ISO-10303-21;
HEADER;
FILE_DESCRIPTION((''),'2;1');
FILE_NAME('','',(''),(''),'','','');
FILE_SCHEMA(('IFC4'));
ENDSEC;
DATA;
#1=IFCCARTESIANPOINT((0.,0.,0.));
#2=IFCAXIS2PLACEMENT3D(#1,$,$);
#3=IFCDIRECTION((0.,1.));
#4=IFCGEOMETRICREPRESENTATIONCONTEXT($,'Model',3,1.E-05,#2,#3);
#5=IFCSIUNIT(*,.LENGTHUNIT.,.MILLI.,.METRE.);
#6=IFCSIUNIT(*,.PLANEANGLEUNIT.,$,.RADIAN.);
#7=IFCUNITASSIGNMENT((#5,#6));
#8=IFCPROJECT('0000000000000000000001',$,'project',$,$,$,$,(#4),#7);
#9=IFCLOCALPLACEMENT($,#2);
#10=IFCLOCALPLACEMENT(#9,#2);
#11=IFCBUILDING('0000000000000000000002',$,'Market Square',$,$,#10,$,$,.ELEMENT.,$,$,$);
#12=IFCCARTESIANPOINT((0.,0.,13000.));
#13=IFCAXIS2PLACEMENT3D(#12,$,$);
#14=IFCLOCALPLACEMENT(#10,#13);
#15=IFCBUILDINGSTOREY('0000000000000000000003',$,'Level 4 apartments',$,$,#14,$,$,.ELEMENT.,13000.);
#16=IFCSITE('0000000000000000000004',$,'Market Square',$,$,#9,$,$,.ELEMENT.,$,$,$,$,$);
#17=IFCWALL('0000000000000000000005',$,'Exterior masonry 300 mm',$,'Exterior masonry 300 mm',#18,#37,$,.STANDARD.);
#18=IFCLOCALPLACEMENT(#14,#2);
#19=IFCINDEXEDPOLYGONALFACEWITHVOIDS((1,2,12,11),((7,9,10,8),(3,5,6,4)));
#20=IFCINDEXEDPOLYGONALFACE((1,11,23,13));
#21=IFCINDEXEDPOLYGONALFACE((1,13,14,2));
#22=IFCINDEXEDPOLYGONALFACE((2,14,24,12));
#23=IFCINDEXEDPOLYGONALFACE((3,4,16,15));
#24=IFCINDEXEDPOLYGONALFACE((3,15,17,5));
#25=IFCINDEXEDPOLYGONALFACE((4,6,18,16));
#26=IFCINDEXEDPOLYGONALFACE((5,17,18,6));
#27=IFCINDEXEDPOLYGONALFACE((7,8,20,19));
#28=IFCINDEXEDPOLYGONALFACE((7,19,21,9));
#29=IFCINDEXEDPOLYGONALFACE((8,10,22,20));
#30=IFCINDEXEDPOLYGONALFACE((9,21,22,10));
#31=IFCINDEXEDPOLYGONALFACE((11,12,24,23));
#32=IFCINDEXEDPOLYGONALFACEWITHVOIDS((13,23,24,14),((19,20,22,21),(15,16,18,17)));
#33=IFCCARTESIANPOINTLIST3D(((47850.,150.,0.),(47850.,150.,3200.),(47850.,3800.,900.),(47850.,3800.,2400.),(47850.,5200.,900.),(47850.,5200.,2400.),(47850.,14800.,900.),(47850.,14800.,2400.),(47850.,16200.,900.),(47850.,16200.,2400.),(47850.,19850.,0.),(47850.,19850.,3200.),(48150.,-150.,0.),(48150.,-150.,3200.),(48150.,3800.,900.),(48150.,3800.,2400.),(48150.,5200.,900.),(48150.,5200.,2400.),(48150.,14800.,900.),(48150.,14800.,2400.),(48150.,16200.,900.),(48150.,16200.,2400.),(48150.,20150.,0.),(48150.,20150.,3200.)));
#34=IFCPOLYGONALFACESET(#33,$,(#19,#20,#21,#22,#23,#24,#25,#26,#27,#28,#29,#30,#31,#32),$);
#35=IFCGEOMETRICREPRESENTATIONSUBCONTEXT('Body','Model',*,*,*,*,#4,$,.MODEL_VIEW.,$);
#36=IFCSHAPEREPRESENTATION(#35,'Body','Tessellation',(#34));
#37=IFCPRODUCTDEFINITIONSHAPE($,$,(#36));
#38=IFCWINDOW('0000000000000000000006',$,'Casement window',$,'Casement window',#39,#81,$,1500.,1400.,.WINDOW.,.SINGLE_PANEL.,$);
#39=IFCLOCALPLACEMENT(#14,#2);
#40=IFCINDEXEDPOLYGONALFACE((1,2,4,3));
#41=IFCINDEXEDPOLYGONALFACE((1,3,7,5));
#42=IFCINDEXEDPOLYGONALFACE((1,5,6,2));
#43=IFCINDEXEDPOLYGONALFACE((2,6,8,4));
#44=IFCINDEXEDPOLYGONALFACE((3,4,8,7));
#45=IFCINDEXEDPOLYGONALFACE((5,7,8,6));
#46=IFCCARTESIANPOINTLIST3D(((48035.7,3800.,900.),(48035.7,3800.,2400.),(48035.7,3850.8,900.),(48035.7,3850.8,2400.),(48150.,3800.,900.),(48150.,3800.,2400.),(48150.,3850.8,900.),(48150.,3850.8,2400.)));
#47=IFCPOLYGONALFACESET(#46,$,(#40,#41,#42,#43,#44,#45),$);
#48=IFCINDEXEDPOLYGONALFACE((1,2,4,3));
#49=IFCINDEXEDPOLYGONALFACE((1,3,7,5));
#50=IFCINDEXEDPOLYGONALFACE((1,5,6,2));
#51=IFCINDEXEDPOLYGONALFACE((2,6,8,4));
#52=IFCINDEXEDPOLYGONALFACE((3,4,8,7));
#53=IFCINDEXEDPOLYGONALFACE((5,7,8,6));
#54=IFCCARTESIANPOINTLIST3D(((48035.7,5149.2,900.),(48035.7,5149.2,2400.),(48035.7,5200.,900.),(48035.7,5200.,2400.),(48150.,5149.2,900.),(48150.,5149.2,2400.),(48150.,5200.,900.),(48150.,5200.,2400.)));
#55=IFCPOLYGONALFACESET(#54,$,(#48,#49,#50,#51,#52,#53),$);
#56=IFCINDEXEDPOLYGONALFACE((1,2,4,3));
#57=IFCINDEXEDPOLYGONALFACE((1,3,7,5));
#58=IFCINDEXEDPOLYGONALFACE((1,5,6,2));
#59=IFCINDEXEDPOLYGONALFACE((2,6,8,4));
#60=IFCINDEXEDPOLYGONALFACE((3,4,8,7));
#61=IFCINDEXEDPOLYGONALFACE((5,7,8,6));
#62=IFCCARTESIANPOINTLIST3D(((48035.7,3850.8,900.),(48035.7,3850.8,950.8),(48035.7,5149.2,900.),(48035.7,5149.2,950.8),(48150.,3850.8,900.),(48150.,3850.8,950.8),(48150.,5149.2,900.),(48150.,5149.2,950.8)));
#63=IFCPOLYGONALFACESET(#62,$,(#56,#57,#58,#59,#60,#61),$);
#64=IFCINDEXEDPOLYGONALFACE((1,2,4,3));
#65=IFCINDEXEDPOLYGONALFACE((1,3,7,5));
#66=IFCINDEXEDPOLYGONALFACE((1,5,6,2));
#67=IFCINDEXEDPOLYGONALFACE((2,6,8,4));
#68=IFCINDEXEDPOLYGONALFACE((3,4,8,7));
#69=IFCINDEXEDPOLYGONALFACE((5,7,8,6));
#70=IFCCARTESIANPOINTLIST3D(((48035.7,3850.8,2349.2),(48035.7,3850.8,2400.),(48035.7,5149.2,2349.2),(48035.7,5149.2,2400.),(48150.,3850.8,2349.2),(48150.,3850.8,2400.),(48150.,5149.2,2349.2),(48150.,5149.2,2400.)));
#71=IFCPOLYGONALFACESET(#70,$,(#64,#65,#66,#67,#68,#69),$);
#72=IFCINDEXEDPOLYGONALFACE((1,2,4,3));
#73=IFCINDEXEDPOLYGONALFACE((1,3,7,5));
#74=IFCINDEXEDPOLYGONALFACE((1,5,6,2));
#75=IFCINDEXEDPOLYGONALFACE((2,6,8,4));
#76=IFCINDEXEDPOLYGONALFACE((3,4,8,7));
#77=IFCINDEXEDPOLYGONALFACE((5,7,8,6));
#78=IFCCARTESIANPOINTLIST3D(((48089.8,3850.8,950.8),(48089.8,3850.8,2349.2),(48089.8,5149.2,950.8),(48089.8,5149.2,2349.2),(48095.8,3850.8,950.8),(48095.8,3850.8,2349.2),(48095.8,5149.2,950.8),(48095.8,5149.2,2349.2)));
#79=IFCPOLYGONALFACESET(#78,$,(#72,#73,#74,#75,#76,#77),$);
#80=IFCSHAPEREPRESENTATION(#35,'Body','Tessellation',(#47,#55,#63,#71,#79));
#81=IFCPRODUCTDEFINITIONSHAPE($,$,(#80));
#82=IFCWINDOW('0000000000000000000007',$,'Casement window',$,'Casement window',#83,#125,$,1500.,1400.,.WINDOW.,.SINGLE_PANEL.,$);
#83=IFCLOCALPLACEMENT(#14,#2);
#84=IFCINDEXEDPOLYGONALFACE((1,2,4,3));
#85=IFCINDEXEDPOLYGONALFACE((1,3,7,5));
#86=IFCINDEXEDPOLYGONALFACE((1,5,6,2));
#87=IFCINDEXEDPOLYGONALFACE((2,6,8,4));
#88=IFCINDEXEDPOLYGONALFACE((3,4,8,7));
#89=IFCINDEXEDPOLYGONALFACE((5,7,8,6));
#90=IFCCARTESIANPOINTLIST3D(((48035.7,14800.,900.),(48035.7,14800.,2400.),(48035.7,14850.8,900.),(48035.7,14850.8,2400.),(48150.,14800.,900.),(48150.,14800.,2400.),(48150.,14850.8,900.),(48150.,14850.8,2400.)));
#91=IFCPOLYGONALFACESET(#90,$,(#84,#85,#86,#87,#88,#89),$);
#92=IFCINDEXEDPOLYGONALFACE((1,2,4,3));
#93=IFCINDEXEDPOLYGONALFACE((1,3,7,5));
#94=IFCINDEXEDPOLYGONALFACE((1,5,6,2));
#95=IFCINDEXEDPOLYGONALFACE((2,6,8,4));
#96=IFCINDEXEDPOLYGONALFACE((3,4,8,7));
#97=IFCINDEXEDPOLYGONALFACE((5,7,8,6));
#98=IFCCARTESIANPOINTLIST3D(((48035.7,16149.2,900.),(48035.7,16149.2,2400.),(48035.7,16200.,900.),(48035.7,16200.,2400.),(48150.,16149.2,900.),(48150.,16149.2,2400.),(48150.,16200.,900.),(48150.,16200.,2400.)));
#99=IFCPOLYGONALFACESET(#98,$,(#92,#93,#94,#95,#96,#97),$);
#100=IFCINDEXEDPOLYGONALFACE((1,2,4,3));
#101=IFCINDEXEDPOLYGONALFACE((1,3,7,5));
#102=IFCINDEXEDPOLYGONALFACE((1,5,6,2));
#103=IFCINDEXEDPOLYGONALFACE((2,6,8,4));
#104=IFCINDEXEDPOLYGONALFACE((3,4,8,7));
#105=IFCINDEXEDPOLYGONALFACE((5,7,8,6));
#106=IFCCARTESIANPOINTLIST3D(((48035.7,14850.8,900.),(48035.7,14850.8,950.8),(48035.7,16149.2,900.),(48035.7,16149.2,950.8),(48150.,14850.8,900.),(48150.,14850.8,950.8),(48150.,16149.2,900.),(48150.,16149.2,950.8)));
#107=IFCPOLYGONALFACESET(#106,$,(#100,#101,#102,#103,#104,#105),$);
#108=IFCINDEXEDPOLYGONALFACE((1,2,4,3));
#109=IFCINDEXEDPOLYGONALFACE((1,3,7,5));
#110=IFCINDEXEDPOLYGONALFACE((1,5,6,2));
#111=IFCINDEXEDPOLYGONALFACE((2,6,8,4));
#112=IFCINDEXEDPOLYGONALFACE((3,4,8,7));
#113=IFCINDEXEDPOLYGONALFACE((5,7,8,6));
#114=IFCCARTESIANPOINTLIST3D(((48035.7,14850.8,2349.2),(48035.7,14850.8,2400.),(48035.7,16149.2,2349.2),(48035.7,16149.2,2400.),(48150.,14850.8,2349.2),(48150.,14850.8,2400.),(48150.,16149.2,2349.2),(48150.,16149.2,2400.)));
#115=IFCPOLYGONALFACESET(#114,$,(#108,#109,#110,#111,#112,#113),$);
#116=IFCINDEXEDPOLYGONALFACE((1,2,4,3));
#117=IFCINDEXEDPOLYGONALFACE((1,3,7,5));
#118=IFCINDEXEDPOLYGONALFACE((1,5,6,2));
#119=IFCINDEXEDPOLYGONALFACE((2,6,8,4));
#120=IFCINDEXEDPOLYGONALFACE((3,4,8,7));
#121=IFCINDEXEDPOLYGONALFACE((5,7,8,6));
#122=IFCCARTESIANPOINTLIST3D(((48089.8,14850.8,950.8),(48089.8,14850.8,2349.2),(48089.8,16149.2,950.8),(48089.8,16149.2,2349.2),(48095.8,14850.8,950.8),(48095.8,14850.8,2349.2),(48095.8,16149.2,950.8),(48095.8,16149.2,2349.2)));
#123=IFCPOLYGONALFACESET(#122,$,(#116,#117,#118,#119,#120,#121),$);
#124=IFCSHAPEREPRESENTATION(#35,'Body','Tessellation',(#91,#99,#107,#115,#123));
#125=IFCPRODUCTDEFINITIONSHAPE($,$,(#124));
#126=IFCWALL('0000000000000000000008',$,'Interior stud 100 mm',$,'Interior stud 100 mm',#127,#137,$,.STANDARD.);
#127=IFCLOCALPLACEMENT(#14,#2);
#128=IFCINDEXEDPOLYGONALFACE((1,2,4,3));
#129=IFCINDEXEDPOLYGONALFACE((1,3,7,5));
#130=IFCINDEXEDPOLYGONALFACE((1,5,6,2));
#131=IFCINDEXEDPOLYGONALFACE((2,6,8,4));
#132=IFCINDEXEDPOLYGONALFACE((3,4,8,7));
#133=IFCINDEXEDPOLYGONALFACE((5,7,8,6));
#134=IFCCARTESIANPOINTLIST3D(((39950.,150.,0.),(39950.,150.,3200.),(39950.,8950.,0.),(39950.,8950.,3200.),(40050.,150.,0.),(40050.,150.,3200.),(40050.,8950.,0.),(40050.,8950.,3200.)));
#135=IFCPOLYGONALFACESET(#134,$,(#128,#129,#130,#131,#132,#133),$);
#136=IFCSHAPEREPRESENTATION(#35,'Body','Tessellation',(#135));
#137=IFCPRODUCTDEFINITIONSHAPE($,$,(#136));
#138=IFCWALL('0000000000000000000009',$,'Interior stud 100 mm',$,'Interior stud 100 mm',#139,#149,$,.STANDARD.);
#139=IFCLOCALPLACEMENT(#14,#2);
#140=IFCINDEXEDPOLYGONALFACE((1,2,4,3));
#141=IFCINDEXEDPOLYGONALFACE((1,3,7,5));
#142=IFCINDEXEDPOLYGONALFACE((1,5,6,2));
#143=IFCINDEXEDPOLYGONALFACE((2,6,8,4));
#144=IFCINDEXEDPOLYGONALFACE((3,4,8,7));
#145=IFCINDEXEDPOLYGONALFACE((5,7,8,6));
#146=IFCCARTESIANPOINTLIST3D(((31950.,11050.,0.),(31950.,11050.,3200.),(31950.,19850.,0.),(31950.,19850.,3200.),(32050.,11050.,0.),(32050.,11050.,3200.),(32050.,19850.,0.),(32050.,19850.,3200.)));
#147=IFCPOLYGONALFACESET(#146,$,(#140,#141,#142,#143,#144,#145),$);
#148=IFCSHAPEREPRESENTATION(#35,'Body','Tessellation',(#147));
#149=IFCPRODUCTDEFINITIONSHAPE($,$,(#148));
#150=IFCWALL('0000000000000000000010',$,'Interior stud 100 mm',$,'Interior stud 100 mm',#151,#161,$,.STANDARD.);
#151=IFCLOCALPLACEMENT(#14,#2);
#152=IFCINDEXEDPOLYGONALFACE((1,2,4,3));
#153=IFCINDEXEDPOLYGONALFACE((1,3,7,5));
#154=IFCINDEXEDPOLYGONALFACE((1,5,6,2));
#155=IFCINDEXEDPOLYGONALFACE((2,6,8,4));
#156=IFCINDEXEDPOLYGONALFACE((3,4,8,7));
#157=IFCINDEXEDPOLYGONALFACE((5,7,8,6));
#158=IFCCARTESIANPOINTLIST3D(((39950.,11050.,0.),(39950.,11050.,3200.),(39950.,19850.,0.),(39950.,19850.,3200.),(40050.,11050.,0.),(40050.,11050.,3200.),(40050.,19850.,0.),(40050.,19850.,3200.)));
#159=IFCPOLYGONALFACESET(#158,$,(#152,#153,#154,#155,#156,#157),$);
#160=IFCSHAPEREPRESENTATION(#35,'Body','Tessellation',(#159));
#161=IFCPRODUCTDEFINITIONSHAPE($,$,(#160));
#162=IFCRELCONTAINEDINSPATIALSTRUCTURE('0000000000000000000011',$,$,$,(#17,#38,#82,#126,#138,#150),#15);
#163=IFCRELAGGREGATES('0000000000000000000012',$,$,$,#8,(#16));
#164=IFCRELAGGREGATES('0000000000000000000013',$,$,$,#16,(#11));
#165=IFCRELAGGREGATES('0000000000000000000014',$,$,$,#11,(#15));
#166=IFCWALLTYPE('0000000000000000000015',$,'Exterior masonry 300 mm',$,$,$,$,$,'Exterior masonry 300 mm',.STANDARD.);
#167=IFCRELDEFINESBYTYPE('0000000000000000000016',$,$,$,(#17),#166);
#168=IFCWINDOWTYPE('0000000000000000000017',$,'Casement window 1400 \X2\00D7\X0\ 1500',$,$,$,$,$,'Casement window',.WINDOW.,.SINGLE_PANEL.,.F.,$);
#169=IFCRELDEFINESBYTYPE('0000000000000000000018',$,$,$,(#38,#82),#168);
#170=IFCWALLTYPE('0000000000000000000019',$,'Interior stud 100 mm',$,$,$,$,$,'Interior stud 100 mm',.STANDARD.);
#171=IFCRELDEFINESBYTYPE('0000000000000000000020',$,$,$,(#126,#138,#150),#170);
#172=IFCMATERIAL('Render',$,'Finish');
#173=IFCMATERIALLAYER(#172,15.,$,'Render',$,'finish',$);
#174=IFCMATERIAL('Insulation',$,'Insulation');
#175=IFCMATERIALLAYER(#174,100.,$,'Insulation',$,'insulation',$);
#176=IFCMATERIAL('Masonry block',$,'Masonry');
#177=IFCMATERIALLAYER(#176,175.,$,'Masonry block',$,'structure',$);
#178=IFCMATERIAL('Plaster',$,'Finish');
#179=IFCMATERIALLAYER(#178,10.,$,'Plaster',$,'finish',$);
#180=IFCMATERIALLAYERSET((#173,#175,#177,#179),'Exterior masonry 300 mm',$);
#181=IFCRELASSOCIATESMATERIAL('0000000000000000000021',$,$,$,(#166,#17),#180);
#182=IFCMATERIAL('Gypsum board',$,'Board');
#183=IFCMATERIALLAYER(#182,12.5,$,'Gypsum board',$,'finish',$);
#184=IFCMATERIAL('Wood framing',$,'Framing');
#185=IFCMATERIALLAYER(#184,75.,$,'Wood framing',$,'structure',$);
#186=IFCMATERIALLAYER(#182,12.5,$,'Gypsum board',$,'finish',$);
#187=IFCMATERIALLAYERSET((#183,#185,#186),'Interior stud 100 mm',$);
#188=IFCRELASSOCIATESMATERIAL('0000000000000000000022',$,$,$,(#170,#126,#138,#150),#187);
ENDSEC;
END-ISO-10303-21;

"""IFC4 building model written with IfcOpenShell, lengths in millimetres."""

from ifc_helpers import new_model, si_unit, direction, frame, origin, origin_with_axes, place, context, subcontext, project, spatial, polyline, outline, extrude, material, layer, layer_set, layer_usage, type_object, element, fill, save


model = new_model("IFC4")

# Units and contexts
model_context = context("Model", 3, precision=1e-05, world=origin(), true_north=direction((0.0, 1.0)))
body_context = subcontext(model_context, "Body", "Model", "MODEL_VIEW")
ifc_project = project(units=[si_unit("LENGTHUNIT", "METRE", prefix="MILLI"), si_unit("PLANEANGLEUNIT", "RADIAN")], contexts=[model_context])

# Site, building, storey
site_placement = place(None, origin())
site = spatial("IfcSite", under=ifc_project, at=site_placement, Name="Market Square", CompositionType="ELEMENT")
building_placement = place(site_placement, origin())
building = spatial("IfcBuilding", under=site, at=building_placement, Name="Market Square", CompositionType="ELEMENT")
storey_placement = place(building_placement, frame((0.0, 0.0, 13000.0)))
storey = spatial("IfcBuildingStorey", under=building, at=storey_placement, Name="Level 4 apartments", CompositionType="ELEMENT", Elevation=13000.0)

# Wall, openings, windows
ifc_material_1 = material(Name="Render", Category="Finish")
ifc_layer_1 = layer(ifc_material_1, 15.0, Name="Render", Category="finish")
ifc_material_2 = material(Name="Insulation", Category="Insulation")
ifc_layer_2 = layer(ifc_material_2, 100.0, Name="Insulation", Category="insulation")
ifc_material_3 = material(Name="Masonry block", Category="Masonry")
ifc_layer_3 = layer(ifc_material_3, 175.0, Name="Masonry block", Category="structure")
ifc_material_4 = material(Name="Plaster", Category="Finish")
ifc_layer_4 = layer(ifc_material_4, 10.0, Name="Plaster", Category="finish")
ifc_layer_set_1 = layer_set([ifc_layer_1, ifc_layer_2, ifc_layer_3, ifc_layer_4], Name="Exterior masonry 300 mm")
ifc_layer_usage_1 = layer_usage(ifc_layer_set_1, "AXIS2", "POSITIVE", -150.0)
wall_type_1 = type_object("IfcWallType", Name="Exterior masonry 300 mm", ElementType="Exterior masonry 300 mm", PredefinedType="STANDARD", material=ifc_layer_set_1)
wall_1_placement = place(storey_placement, frame((48000.0, 0.0, 0.0), z_axis=(0.0, 0.0, 1.0), x_axis=(0.0, 1.0, 0.0)))
wall_1 = element("IfcWall", 1, at=wall_1_placement, inside=storey, type_object=wall_type_1, material=ifc_layer_usage_1, Name="Exterior masonry 300 mm", ObjectType="Exterior masonry 300 mm", PredefinedType="STANDARD", context=body_context, shape_type="SweptSolid", body=[
    extrude(outline(polyline([(-150.0, -150.0), (20150.0, -150.0), (19850.0, 150.0), (150.0, 150.0), (-150.0, -150.0)])), origin(), (0.0, 0.0, 1.0), 3200.0),
])
opening_1_placement = place(wall_1_placement, frame((3800.0, 0.0, 900.0), z_axis=(0.0, 0.0, 1.0), x_axis=(1.0, 0.0, 0.0)))
opening_1 = element("IfcOpeningElement", 2, at=opening_1_placement, cuts=wall_1, PredefinedType="OPENING", context=body_context, shape_type="SweptSolid", body=[
    extrude(outline(polyline([(0.0, -160.0), (1400.0, -160.0), (1400.0, 160.0), (0.0, 160.0), (0.0, -160.0)])), origin(), (0.0, 0.0, 1.0), 1500.0),
])
opening_2_placement = place(wall_1_placement, frame((14800.0, 0.0, 900.0), z_axis=(0.0, 0.0, 1.0), x_axis=(1.0, 0.0, 0.0)))
opening_2 = element("IfcOpeningElement", 3, at=opening_2_placement, cuts=wall_1, PredefinedType="OPENING", context=body_context, shape_type="SweptSolid", body=[
    extrude(outline(polyline([(0.0, -160.0), (1400.0, -160.0), (1400.0, 160.0), (0.0, 160.0), (0.0, -160.0)])), origin(), (0.0, 0.0, 1.0), 1500.0),
])
window_type = type_object("IfcWindowType", Name="Casement window 1400 × 1500", ElementType="Casement window", ParameterTakesPrecedence=False, PartitioningType="SINGLE_PANEL", PredefinedType="WINDOW")
window_1_placement = place(opening_1_placement, origin_with_axes())
window_1 = element("IfcWindow", 4, at=window_1_placement, inside=storey, type_object=window_type, Name="Casement window", ObjectType="Casement window", OverallHeight=1500.0, OverallWidth=1400.0, PartitioningType="SINGLE_PANEL", PredefinedType="WINDOW", context=body_context, shape_type="SweptSolid", body=[
    extrude(outline(polyline([(0.0, -150.0), (50.8, -150.0), (50.8, -35.7), (0.0, -35.7), (0.0, -150.0)])), origin(), (0.0, 0.0, 1.0), 1500.0),
    extrude(outline(polyline([(1349.2, -150.0), (1400.0, -150.0), (1400.0, -35.7), (1349.2, -35.7), (1349.2, -150.0)])), origin(), (0.0, 0.0, 1.0), 1500.0),
    extrude(outline(polyline([(50.8, -150.0), (1349.2, -150.0), (1349.2, -35.7), (50.8, -35.7), (50.8, -150.0)])), origin(), (0.0, 0.0, 1.0), 50.8),
    extrude(outline(polyline([(50.8, -150.0), (1349.2, -150.0), (1349.2, -35.7), (50.8, -35.7), (50.8, -150.0)])), frame((0.0, 0.0, 1449.2)), (0.0, 0.0, 1.0), 50.8),
    extrude(outline(polyline([(50.8, -95.8), (1349.2, -95.8), (1349.2, -89.8), (50.8, -89.8), (50.8, -95.8)])), frame((0.0, 0.0, 50.8)), (0.0, 0.0, 1.0), 1398.4),
])
fill(opening_1, window_1)
window_2_placement = place(opening_2_placement, origin_with_axes())
window_2 = element("IfcWindow", 5, at=window_2_placement, inside=storey, type_object=window_type, Name="Casement window", ObjectType="Casement window", OverallHeight=1500.0, OverallWidth=1400.0, PartitioningType="SINGLE_PANEL", PredefinedType="WINDOW", context=body_context, shape_type="SweptSolid", body=[
    extrude(outline(polyline([(0.0, -150.0), (50.8, -150.0), (50.8, -35.7), (0.0, -35.7), (0.0, -150.0)])), origin(), (0.0, 0.0, 1.0), 1500.0),
    extrude(outline(polyline([(1349.2, -150.0), (1400.0, -150.0), (1400.0, -35.7), (1349.2, -35.7), (1349.2, -150.0)])), origin(), (0.0, 0.0, 1.0), 1500.0),
    extrude(outline(polyline([(50.8, -150.0), (1349.2, -150.0), (1349.2, -35.7), (50.8, -35.7), (50.8, -150.0)])), origin(), (0.0, 0.0, 1.0), 50.8),
    extrude(outline(polyline([(50.8, -150.0), (1349.2, -150.0), (1349.2, -35.7), (50.8, -35.7), (50.8, -150.0)])), frame((0.0, 0.0, 1449.2)), (0.0, 0.0, 1.0), 50.8),
    extrude(outline(polyline([(50.8, -95.8), (1349.2, -95.8), (1349.2, -89.8), (50.8, -89.8), (50.8, -95.8)])), frame((0.0, 0.0, 50.8)), (0.0, 0.0, 1.0), 1398.4),
])
fill(opening_2, window_2)

# Walls
ifc_material_5 = material(Name="Gypsum board", Category="Board")
ifc_layer_5 = layer(ifc_material_5, 12.5, Name="Gypsum board", Category="finish")
ifc_material_6 = material(Name="Wood framing", Category="Framing")
ifc_layer_6 = layer(ifc_material_6, 75.0, Name="Wood framing", Category="structure")
ifc_layer_7 = layer(ifc_material_5, 12.5, Name="Gypsum board", Category="finish")
ifc_layer_set_2 = layer_set([ifc_layer_5, ifc_layer_6, ifc_layer_7], Name="Interior stud 100 mm")
ifc_layer_usage_2 = layer_usage(ifc_layer_set_2, "AXIS2", "NEGATIVE", 50.0)
wall_type_2 = type_object("IfcWallType", Name="Interior stud 100 mm", ElementType="Interior stud 100 mm", PredefinedType="STANDARD", material=ifc_layer_set_2)
wall_2_placement = place(storey_placement, frame((40000.0, 0.0, 0.0), z_axis=(0.0, 0.0, 1.0), x_axis=(0.0, 1.0, 0.0)))
element("IfcWall", 6, at=wall_2_placement, inside=storey, type_object=wall_type_2, material=ifc_layer_usage_2, Name="Interior stud 100 mm", ObjectType="Interior stud 100 mm", PredefinedType="STANDARD", context=body_context, shape_type="SweptSolid", body=[
    extrude(outline(polyline([(150.0, -50.0), (8950.0, -50.0), (8950.0, 50.0), (150.0, 50.0), (150.0, -50.0)])), origin(), (0.0, 0.0, 1.0), 3200.0),
])
ifc_layer_usage_3 = layer_usage(ifc_layer_set_2, "AXIS2", "NEGATIVE", 50.0)
wall_3_placement = place(storey_placement, frame((32000.0, 11000.0, 0.0), z_axis=(0.0, 0.0, 1.0), x_axis=(0.0, 1.0, 0.0)))
element("IfcWall", 7, at=wall_3_placement, inside=storey, type_object=wall_type_2, material=ifc_layer_usage_3, Name="Interior stud 100 mm", ObjectType="Interior stud 100 mm", PredefinedType="STANDARD", context=body_context, shape_type="SweptSolid", body=[
    extrude(outline(polyline([(50.0, -50.0), (8850.0, -50.0), (8850.0, 50.0), (50.0, 50.0), (50.0, -50.0)])), origin(), (0.0, 0.0, 1.0), 3200.0),
])
ifc_layer_usage_4 = layer_usage(ifc_layer_set_2, "AXIS2", "NEGATIVE", 50.0)
wall_4_placement = place(storey_placement, frame((40000.0, 11000.0, 0.0), z_axis=(0.0, 0.0, 1.0), x_axis=(0.0, 1.0, 0.0)))
element("IfcWall", 8, at=wall_4_placement, inside=storey, type_object=wall_type_2, material=ifc_layer_usage_4, Name="Interior stud 100 mm", ObjectType="Interior stud 100 mm", PredefinedType="STANDARD", context=body_context, shape_type="SweptSolid", body=[
    extrude(outline(polyline([(50.0, -50.0), (8850.0, -50.0), (8850.0, 50.0), (50.0, 50.0), (50.0, -50.0)])), origin(), (0.0, 0.0, 1.0), 3200.0),
])

save(model, "model.ifc")
